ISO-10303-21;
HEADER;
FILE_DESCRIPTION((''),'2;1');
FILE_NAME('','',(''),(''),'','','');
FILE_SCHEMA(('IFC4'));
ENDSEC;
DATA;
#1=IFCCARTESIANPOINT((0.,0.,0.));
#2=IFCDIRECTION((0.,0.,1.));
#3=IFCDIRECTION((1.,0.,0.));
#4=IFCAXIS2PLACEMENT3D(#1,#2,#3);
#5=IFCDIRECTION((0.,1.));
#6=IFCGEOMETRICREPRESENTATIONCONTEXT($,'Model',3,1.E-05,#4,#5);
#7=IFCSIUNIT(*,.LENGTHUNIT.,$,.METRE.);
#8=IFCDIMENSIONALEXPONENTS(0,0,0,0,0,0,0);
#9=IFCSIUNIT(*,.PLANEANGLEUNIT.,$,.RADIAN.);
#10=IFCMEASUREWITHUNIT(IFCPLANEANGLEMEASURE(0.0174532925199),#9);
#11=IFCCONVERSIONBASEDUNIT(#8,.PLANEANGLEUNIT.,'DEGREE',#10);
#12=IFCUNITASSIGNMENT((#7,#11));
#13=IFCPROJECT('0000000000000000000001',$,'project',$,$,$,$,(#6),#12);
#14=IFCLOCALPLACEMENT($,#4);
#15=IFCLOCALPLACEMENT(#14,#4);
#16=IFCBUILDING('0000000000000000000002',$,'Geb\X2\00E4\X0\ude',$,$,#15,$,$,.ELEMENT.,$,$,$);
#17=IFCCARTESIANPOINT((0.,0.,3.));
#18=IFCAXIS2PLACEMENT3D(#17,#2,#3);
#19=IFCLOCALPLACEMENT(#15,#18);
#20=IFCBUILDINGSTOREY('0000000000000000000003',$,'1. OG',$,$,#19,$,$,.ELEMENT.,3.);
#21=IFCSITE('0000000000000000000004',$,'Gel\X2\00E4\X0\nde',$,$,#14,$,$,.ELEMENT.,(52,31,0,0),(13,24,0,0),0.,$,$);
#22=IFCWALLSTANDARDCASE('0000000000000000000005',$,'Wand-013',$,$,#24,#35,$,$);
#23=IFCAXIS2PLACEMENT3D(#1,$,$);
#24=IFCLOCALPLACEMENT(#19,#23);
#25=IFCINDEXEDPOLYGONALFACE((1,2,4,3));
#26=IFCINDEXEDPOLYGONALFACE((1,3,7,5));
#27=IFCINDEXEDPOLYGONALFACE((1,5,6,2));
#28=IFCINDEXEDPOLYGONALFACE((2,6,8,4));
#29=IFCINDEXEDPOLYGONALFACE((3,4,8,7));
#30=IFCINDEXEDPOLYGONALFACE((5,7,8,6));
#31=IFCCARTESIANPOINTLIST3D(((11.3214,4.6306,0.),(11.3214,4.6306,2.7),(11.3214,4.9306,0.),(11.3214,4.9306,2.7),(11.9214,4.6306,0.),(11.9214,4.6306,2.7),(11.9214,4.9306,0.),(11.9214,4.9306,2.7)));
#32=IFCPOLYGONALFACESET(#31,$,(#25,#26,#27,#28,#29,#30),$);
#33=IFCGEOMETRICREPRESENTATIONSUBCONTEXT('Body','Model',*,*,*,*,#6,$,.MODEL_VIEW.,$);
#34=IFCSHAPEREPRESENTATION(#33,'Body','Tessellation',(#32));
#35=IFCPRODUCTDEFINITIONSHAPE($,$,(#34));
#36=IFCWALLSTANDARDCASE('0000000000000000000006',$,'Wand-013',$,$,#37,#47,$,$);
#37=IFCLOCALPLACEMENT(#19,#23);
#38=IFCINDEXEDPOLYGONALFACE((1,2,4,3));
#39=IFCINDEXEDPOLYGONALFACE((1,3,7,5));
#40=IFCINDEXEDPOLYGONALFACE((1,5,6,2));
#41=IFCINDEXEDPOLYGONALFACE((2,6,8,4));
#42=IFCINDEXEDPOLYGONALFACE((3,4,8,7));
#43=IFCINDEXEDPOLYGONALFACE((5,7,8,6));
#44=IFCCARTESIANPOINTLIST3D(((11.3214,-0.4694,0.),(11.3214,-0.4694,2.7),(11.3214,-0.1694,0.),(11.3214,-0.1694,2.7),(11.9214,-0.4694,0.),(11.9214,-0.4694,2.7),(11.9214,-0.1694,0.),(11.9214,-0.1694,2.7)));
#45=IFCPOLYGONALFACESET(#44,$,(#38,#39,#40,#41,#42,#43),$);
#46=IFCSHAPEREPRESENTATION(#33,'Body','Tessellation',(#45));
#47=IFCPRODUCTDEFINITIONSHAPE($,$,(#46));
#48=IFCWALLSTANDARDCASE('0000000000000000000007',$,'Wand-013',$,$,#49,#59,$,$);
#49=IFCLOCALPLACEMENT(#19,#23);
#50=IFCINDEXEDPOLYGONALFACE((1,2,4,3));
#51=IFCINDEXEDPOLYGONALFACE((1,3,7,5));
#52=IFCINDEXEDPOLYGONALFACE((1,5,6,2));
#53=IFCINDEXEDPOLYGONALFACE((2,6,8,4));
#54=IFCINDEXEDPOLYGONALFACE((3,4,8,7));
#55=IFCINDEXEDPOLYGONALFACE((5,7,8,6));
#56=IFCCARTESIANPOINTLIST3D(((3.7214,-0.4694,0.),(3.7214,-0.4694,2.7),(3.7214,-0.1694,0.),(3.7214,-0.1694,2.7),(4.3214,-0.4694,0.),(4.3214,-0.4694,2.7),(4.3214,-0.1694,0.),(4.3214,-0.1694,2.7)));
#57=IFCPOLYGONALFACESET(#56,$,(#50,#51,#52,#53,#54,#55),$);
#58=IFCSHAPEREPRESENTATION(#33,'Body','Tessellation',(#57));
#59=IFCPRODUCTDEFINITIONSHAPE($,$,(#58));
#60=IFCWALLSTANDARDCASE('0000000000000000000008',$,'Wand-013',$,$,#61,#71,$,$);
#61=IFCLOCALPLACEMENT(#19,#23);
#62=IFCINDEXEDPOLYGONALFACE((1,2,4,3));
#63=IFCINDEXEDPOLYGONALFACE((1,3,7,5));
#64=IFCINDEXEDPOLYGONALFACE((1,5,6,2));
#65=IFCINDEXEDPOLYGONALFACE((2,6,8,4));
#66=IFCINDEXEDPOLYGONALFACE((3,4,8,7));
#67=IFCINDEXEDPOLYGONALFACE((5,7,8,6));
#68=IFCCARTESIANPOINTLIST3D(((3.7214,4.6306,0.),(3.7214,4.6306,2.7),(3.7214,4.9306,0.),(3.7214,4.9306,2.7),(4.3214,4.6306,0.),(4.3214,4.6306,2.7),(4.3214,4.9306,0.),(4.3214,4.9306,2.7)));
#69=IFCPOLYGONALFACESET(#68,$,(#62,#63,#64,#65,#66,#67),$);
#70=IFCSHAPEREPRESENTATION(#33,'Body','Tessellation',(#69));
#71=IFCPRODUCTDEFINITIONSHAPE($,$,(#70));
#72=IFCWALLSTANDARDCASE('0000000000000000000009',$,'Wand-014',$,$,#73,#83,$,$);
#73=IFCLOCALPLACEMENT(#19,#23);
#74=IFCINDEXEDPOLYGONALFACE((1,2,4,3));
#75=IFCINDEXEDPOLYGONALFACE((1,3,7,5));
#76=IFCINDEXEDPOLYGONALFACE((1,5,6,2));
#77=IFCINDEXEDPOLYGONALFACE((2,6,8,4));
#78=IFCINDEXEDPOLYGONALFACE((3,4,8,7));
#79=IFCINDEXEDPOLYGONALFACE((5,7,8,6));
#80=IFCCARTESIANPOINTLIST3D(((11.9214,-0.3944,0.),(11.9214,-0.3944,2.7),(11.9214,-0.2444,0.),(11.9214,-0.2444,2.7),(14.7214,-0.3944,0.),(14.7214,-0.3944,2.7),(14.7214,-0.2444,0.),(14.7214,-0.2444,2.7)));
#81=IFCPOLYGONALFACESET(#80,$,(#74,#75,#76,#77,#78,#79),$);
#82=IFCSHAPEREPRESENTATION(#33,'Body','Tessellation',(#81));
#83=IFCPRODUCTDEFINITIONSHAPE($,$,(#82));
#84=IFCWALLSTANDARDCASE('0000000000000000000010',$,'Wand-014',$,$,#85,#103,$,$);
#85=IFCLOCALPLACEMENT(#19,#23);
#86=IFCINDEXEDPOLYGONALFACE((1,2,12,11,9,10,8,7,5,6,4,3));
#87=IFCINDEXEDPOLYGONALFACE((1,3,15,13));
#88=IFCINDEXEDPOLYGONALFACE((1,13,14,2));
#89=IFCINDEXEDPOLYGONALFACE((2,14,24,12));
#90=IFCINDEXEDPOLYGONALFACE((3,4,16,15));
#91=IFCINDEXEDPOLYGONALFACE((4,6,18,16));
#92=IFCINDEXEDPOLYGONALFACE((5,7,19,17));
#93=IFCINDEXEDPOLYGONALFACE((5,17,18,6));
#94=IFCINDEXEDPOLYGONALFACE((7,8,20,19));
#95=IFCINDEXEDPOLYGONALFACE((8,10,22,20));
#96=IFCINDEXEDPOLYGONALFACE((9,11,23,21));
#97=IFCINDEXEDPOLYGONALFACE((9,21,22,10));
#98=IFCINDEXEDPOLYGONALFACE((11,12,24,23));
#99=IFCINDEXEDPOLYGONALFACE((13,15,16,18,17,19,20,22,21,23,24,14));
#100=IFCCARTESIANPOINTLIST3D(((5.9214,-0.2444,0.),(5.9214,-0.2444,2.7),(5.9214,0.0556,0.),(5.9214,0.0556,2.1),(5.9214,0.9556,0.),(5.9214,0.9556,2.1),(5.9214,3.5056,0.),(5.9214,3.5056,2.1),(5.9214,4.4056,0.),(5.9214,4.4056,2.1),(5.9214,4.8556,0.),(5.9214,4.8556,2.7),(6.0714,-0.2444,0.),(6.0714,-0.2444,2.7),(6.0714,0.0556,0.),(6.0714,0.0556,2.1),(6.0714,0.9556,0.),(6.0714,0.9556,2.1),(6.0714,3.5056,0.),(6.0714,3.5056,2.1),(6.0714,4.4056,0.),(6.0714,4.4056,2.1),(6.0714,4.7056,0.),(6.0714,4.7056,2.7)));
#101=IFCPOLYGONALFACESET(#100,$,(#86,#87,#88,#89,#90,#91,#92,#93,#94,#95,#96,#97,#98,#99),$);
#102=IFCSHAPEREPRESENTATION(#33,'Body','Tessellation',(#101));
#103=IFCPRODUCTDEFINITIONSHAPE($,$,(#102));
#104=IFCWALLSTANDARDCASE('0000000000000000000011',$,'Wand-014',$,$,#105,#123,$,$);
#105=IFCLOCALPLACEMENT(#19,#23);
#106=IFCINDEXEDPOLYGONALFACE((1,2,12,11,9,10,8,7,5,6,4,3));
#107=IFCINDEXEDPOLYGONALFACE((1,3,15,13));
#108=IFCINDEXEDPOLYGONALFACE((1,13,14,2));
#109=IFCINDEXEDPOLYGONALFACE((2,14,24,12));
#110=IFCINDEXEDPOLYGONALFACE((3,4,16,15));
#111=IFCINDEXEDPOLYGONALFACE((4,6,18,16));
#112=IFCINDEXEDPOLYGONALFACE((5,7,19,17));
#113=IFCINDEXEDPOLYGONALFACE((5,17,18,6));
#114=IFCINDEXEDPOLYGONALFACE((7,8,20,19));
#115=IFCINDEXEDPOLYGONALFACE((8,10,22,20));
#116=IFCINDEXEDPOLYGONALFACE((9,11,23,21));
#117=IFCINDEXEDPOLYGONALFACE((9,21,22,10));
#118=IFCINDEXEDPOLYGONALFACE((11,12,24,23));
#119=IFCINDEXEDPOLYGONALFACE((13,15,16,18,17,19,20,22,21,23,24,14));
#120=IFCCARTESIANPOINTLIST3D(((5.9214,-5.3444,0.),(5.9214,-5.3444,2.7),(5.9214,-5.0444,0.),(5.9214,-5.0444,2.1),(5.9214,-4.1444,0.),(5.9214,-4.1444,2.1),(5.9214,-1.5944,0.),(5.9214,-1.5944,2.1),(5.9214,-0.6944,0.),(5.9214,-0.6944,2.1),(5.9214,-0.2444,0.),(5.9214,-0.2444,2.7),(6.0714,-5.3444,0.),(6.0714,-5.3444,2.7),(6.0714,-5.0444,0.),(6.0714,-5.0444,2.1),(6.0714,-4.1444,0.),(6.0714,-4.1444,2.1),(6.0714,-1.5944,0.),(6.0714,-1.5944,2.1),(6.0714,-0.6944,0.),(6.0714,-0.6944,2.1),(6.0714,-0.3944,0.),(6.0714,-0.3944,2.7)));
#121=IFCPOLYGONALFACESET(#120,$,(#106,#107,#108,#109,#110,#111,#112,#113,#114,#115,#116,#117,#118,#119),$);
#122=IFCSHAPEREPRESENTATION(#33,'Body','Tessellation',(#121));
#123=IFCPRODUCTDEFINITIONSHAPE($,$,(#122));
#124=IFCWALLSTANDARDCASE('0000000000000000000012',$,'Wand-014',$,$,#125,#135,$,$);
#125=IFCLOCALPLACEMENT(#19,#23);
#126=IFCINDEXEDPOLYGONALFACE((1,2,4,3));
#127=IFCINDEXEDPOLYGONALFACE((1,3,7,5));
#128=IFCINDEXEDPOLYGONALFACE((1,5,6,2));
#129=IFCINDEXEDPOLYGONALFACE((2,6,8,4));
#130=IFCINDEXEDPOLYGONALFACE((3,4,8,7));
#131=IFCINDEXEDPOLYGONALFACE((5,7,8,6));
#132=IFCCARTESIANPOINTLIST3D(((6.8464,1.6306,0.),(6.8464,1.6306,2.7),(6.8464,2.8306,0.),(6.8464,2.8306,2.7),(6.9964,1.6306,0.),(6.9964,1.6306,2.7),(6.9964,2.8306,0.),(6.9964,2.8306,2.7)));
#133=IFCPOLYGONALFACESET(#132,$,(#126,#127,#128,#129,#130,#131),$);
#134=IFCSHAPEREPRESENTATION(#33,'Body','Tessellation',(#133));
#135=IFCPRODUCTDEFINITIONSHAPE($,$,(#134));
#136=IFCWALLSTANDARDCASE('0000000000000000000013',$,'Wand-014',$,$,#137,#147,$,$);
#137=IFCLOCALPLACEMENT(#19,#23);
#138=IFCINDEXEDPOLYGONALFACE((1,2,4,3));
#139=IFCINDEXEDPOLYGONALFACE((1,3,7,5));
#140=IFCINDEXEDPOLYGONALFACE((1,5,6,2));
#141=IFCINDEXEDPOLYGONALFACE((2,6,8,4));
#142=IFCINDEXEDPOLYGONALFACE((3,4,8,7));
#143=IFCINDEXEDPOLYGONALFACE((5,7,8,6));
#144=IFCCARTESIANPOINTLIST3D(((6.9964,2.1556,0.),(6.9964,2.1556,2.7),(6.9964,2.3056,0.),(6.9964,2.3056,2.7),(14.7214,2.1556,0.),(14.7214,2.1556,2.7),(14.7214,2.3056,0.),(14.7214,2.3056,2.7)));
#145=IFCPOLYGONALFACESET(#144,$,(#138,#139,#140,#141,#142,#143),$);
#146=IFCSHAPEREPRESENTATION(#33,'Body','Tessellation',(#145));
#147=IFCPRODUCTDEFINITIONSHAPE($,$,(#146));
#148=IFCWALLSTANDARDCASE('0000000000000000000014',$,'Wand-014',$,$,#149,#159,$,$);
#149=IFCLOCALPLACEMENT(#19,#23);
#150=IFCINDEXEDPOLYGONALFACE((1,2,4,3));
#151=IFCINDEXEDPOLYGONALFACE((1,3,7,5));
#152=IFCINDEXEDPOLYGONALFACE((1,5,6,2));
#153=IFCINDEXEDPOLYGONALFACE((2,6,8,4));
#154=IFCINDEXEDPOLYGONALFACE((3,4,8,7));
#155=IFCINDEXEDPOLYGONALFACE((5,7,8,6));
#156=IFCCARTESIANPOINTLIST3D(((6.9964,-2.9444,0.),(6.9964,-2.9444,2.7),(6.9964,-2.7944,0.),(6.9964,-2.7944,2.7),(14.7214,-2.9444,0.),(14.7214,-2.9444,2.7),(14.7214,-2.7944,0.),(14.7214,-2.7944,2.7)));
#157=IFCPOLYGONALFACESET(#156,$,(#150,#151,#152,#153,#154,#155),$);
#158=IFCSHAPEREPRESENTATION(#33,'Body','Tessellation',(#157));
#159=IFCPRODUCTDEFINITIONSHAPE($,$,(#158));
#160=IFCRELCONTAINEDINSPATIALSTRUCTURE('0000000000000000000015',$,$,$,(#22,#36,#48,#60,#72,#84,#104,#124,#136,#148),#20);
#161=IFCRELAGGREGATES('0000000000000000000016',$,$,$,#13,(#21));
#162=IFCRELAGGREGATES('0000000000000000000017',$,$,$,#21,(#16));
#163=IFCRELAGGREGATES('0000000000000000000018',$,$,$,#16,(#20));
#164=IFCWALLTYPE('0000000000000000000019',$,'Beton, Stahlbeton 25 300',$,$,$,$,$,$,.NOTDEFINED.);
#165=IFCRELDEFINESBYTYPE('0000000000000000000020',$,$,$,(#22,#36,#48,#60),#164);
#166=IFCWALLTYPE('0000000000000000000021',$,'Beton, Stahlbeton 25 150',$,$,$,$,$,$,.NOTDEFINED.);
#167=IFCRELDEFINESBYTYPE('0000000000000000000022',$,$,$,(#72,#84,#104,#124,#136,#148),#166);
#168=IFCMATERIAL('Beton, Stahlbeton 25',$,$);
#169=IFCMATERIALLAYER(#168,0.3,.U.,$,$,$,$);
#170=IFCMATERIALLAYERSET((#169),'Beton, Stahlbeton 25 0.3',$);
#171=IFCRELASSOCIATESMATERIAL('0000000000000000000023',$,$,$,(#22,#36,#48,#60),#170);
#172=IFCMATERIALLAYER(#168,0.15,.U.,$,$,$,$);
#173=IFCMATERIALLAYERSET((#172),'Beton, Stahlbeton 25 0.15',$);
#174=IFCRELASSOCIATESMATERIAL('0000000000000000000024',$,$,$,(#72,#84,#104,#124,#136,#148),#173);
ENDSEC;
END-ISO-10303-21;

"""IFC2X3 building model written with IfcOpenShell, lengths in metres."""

from ifc_helpers import new_model, entity, si_unit, converted_unit, direction, frame, origin_with_axes, origin_2d_with_axis, place, context, subcontext, project, spatial, polyline, rectangle, outline, extrude, material, layer, layer_set, layer_usage, type_object, element, save


model = new_model("IFC2X3")

# Units and contexts
model_context = context("Model", 3, precision=1e-05, world=origin_with_axes(), true_north=direction((0.0, 1.0)))
body_context = subcontext(model_context, "Body", "Model", "MODEL_VIEW")
ifc_project = project(units=[si_unit("LENGTHUNIT", "METRE"), converted_unit("PLANEANGLEUNIT", "DEGREE", entity("IfcPlaneAngleMeasure", 0.0174532925199), si_unit("PLANEANGLEUNIT", "RADIAN"), dimensions=[0, 0, 0, 0, 0, 0, 0])], contexts=[model_context])

# Site, building, storey
site_placement = place(None, origin_with_axes())
site = spatial("IfcSite", under=ifc_project, at=site_placement, Name="Gelände", CompositionType="ELEMENT", RefLatitude=(52, 31, 0, 0), RefLongitude=(13, 24, 0, 0), RefElevation=0.0)
building_placement = place(site_placement, origin_with_axes())
building = spatial("IfcBuilding", under=site, at=building_placement, Name="Gebäude", CompositionType="ELEMENT")
storey_placement = place(building_placement, frame((0.0, 0.0, 3.0), z_axis=(0.0, 0.0, 1.0), x_axis=(1.0, 0.0, 0.0)))
storey = spatial("IfcBuildingStorey", under=building, at=storey_placement, Name="1. OG", CompositionType="ELEMENT", Elevation=3.0)

# Walls
ifc_material = material(Name="Beton, Stahlbeton 25")
ifc_layer_1 = layer(ifc_material, 0.3, ventilated="UNKNOWN")
ifc_layer_set_1 = layer_set([ifc_layer_1], Name="Beton, Stahlbeton 25 0.3")
ifc_layer_usage_1 = layer_usage(ifc_layer_set_1, "AXIS2", "NEGATIVE", 0.3)
wall_type_1 = type_object("IfcWallType", Name="Beton, Stahlbeton 25 300", PredefinedType="NOTDEFINED")
wall_1_placement = place(storey_placement, frame((11.3214, 4.6306, 0.0), z_axis=(0.0, 0.0, 1.0), x_axis=(1.0, 0.0, 0.0)))
element("IfcWallStandardCase", 1, at=wall_1_placement, inside=storey, type_object=wall_type_1, material=ifc_layer_usage_1, Name="Wand-013", context=body_context, shape_type="SweptSolid", body=[
    extrude(outline(polyline([(0.0, 0.0), (0.6, 0.0), (0.6, 0.3), (0.0, 0.3), (0.0, 0.0)])), origin_with_axes(), (0.0, 0.0, 1.0), 2.7),
])
ifc_layer_usage_2 = layer_usage(ifc_layer_set_1, "AXIS2", "NEGATIVE", 0.3)
wall_2_placement = place(storey_placement, frame((11.3214, -0.4694, 0.0), z_axis=(0.0, 0.0, 1.0), x_axis=(1.0, 0.0, 0.0)))
element("IfcWallStandardCase", 2, at=wall_2_placement, inside=storey, type_object=wall_type_1, material=ifc_layer_usage_2, Name="Wand-013", context=body_context, shape_type="SweptSolid", body=[
    extrude(outline(polyline([(0.0, 0.0), (0.6, 0.0), (0.6, 0.3), (0.0, 0.3), (0.0, 0.0)])), origin_with_axes(), (0.0, 0.0, 1.0), 2.7),
])
ifc_layer_usage_3 = layer_usage(ifc_layer_set_1, "AXIS2", "NEGATIVE", 0.3)
wall_3_placement = place(storey_placement, frame((3.7214, -0.4694, 0.0), z_axis=(0.0, 0.0, 1.0), x_axis=(1.0, 0.0, 0.0)))
element("IfcWallStandardCase", 3, at=wall_3_placement, inside=storey, type_object=wall_type_1, material=ifc_layer_usage_3, Name="Wand-013", context=body_context, shape_type="SweptSolid", body=[
    extrude(outline(polyline([(0.0, 0.0), (0.6, 0.0), (0.6, 0.3), (0.0, 0.3), (0.0, 0.0)])), origin_with_axes(), (0.0, 0.0, 1.0), 2.7),
])
ifc_layer_usage_4 = layer_usage(ifc_layer_set_1, "AXIS2", "NEGATIVE", 0.3)
wall_4_placement = place(storey_placement, frame((3.7214, 4.6306, 0.0), z_axis=(0.0, 0.0, 1.0), x_axis=(1.0, 0.0, 0.0)))
element("IfcWallStandardCase", 4, at=wall_4_placement, inside=storey, type_object=wall_type_1, material=ifc_layer_usage_4, Name="Wand-013", context=body_context, shape_type="SweptSolid", body=[
    extrude(outline(polyline([(0.0, 0.0), (0.6, 0.0), (0.6, 0.3), (0.0, 0.3), (0.0, 0.0)])), origin_with_axes(), (0.0, 0.0, 1.0), 2.7),
])
ifc_layer_2 = layer(ifc_material, 0.15, ventilated="UNKNOWN")
ifc_layer_set_2 = layer_set([ifc_layer_2], Name="Beton, Stahlbeton 25 0.15")
wall_type_2 = type_object("IfcWallType", Name="Beton, Stahlbeton 25 150", PredefinedType="NOTDEFINED")
ifc_layer_usage_5 = layer_usage(ifc_layer_set_2, "AXIS2", "NEGATIVE", 0.075)
wall_5_placement = place(storey_placement, frame((14.7214, -0.3194, 0.0), z_axis=(0.0, 0.0, 1.0), x_axis=(-1.0, 0.0, 0.0)))
element("IfcWallStandardCase", 5, at=wall_5_placement, inside=storey, type_object=wall_type_2, material=ifc_layer_usage_5, Name="Wand-014", context=body_context, shape_type="SweptSolid", body=[
    extrude(outline(polyline([(0.0, -0.075), (2.8, -0.075), (2.8, 0.075), (0.0, 0.075), (0.0, -0.075)])), origin_with_axes(), (0.0, 0.0, 1.0), 2.7),
])

# Wall, openings
ifc_layer_usage_6 = layer_usage(ifc_layer_set_2, "AXIS2", "POSITIVE", 0.0)
wall_6_placement = place(storey_placement, frame((5.9214, 4.7806, 0.0), z_axis=(0.0, 0.0, 1.0), x_axis=(0.0, -1.0, 0.0)))
wall_6 = element("IfcWallStandardCase", 6, at=wall_6_placement, inside=storey, type_object=wall_type_2, material=ifc_layer_usage_6, Name="Wand-014", context=body_context, shape_type="SweptSolid", body=[
    extrude(outline(polyline([(-0.075, 0.0), (5.025, 0.0), (5.025, 0.15), (0.075, 0.15), (-0.075, 0.0)])), origin_with_axes(), (0.0, 0.0, 1.0), 2.7),
])
opening_1_placement = place(wall_6_placement, frame((4.275, 0.0, 0.0), z_axis=(0.0, 0.0, 1.0), x_axis=(1.0, 0.0, 0.0)))
element("IfcOpeningElement", 7, at=opening_1_placement, cuts=wall_6, context=body_context, shape_type="SweptSolid", body=[
    extrude(rectangle(XDim=0.9, YDim=2.1, at=origin_2d_with_axis()), frame((0.0, 0.3, 1.05), z_axis=(0.0, -1.0, 0.0), x_axis=(1.0, 0.0, 0.0)), (0.0, 0.0, 1.0), 0.15),
    extrude(rectangle(XDim=0.9, YDim=2.1, at=origin_2d_with_axis()), frame((0.0, 0.0, 1.05), z_axis=(0.0, 1.0, 0.0), x_axis=(1.0, 0.0, 0.0)), (0.0, 0.0, 1.0), 0.15),
])
opening_2_placement = place(wall_6_placement, frame((0.825, 0.0, 0.0), z_axis=(0.0, 0.0, 1.0), x_axis=(1.0, 0.0, 0.0)))
element("IfcOpeningElement", 8, at=opening_2_placement, cuts=wall_6, context=body_context, shape_type="SweptSolid", body=[
    extrude(rectangle(XDim=0.9, YDim=2.1, at=origin_2d_with_axis()), frame((0.0, 0.3, 1.05), z_axis=(0.0, -1.0, 0.0), x_axis=(1.0, 0.0, 0.0)), (0.0, 0.0, 1.0), 0.15),
    extrude(rectangle(XDim=0.9, YDim=2.1, at=origin_2d_with_axis()), frame((0.0, 0.0, 1.05), z_axis=(0.0, 1.0, 0.0), x_axis=(1.0, 0.0, 0.0)), (0.0, 0.0, 1.0), 0.15),
])

# Wall, openings
ifc_layer_usage_7 = layer_usage(ifc_layer_set_2, "AXIS2", "POSITIVE", 0.0)
wall_7_placement = place(storey_placement, frame((5.9214, -0.3194, 0.0), z_axis=(0.0, 0.0, 1.0), x_axis=(0.0, -1.0, 0.0)))
wall_7 = element("IfcWallStandardCase", 9, at=wall_7_placement, inside=storey, type_object=wall_type_2, material=ifc_layer_usage_7, Name="Wand-014", context=body_context, shape_type="SweptSolid", body=[
    extrude(outline(polyline([(-0.075, 0.0), (5.025, 0.0), (5.025, 0.15), (0.075, 0.15), (-0.075, 0.0)])), origin_with_axes(), (0.0, 0.0, 1.0), 2.7),
])
opening_3_placement = place(wall_7_placement, frame((0.825, 0.0, 0.0), z_axis=(0.0, 0.0, 1.0), x_axis=(1.0, 0.0, 0.0)))
element("IfcOpeningElement", 10, at=opening_3_placement, cuts=wall_7, context=body_context, shape_type="SweptSolid", body=[
    extrude(rectangle(XDim=0.9, YDim=2.1, at=origin_2d_with_axis()), frame((0.0, 0.3, 1.05), z_axis=(0.0, -1.0, 0.0), x_axis=(1.0, 0.0, 0.0)), (0.0, 0.0, 1.0), 0.15),
    extrude(rectangle(XDim=0.9, YDim=2.1, at=origin_2d_with_axis()), frame((0.0, 0.0, 1.05), z_axis=(0.0, 1.0, 0.0), x_axis=(1.0, 0.0, 0.0)), (0.0, 0.0, 1.0), 0.15),
])
opening_4_placement = place(wall_7_placement, frame((4.275, 0.0, 0.0), z_axis=(0.0, 0.0, 1.0), x_axis=(1.0, 0.0, 0.0)))
element("IfcOpeningElement", 11, at=opening_4_placement, cuts=wall_7, context=body_context, shape_type="SweptSolid", body=[
    extrude(rectangle(XDim=0.9, YDim=2.1, at=origin_2d_with_axis()), frame((0.0, 0.3, 1.05), z_axis=(0.0, -1.0, 0.0), x_axis=(1.0, 0.0, 0.0)), (0.0, 0.0, 1.0), 0.15),
    extrude(rectangle(XDim=0.9, YDim=2.1, at=origin_2d_with_axis()), frame((0.0, 0.0, 1.05), z_axis=(0.0, 1.0, 0.0), x_axis=(1.0, 0.0, 0.0)), (0.0, 0.0, 1.0), 0.15),
])

# Walls
ifc_layer_usage_8 = layer_usage(ifc_layer_set_2, "AXIS2", "POSITIVE", 0.0)
wall_8_placement = place(storey_placement, frame((6.9964, 1.6306, 0.0), z_axis=(0.0, 0.0, 1.0), x_axis=(0.0, 1.0, 0.0)))
element("IfcWallStandardCase", 12, at=wall_8_placement, inside=storey, type_object=wall_type_2, material=ifc_layer_usage_8, Name="Wand-014", context=body_context, shape_type="SweptSolid", body=[
    extrude(outline(polyline([(0.0, 0.0), (1.2, 0.0), (1.2, 0.15), (0.0, 0.15), (0.0, 0.0)])), origin_with_axes(), (0.0, 0.0, 1.0), 2.7),
])
ifc_layer_usage_9 = layer_usage(ifc_layer_set_2, "AXIS2", "NEGATIVE", 0.075)
wall_9_placement = place(storey_placement, frame((14.7214, 2.2306, 0.0), z_axis=(0.0, 0.0, 1.0), x_axis=(-1.0, 0.0, 0.0)))
element("IfcWallStandardCase", 13, at=wall_9_placement, inside=storey, type_object=wall_type_2, material=ifc_layer_usage_9, Name="Wand-014", context=body_context, shape_type="SweptSolid", body=[
    extrude(outline(polyline([(0.0, -0.075), (7.725, -0.075), (7.725, 0.075), (0.0, 0.075), (0.0, -0.075)])), origin_with_axes(), (0.0, 0.0, 1.0), 2.7),
])
ifc_layer_usage_10 = layer_usage(ifc_layer_set_2, "AXIS2", "NEGATIVE", 0.075)
wall_10_placement = place(storey_placement, frame((14.7214, -2.8694, 0.0), z_axis=(0.0, 0.0, 1.0), x_axis=(-1.0, 0.0, 0.0)))
element("IfcWallStandardCase", 14, at=wall_10_placement, inside=storey, type_object=wall_type_2, material=ifc_layer_usage_10, Name="Wand-014", context=body_context, shape_type="SweptSolid", body=[
    extrude(outline(polyline([(0.0, -0.075), (7.725, -0.075), (7.725, 0.075), (0.0, 0.075), (0.0, -0.075)])), origin_with_axes(), (0.0, 0.0, 1.0), 2.7),
])

save(model, "model.ifc")
